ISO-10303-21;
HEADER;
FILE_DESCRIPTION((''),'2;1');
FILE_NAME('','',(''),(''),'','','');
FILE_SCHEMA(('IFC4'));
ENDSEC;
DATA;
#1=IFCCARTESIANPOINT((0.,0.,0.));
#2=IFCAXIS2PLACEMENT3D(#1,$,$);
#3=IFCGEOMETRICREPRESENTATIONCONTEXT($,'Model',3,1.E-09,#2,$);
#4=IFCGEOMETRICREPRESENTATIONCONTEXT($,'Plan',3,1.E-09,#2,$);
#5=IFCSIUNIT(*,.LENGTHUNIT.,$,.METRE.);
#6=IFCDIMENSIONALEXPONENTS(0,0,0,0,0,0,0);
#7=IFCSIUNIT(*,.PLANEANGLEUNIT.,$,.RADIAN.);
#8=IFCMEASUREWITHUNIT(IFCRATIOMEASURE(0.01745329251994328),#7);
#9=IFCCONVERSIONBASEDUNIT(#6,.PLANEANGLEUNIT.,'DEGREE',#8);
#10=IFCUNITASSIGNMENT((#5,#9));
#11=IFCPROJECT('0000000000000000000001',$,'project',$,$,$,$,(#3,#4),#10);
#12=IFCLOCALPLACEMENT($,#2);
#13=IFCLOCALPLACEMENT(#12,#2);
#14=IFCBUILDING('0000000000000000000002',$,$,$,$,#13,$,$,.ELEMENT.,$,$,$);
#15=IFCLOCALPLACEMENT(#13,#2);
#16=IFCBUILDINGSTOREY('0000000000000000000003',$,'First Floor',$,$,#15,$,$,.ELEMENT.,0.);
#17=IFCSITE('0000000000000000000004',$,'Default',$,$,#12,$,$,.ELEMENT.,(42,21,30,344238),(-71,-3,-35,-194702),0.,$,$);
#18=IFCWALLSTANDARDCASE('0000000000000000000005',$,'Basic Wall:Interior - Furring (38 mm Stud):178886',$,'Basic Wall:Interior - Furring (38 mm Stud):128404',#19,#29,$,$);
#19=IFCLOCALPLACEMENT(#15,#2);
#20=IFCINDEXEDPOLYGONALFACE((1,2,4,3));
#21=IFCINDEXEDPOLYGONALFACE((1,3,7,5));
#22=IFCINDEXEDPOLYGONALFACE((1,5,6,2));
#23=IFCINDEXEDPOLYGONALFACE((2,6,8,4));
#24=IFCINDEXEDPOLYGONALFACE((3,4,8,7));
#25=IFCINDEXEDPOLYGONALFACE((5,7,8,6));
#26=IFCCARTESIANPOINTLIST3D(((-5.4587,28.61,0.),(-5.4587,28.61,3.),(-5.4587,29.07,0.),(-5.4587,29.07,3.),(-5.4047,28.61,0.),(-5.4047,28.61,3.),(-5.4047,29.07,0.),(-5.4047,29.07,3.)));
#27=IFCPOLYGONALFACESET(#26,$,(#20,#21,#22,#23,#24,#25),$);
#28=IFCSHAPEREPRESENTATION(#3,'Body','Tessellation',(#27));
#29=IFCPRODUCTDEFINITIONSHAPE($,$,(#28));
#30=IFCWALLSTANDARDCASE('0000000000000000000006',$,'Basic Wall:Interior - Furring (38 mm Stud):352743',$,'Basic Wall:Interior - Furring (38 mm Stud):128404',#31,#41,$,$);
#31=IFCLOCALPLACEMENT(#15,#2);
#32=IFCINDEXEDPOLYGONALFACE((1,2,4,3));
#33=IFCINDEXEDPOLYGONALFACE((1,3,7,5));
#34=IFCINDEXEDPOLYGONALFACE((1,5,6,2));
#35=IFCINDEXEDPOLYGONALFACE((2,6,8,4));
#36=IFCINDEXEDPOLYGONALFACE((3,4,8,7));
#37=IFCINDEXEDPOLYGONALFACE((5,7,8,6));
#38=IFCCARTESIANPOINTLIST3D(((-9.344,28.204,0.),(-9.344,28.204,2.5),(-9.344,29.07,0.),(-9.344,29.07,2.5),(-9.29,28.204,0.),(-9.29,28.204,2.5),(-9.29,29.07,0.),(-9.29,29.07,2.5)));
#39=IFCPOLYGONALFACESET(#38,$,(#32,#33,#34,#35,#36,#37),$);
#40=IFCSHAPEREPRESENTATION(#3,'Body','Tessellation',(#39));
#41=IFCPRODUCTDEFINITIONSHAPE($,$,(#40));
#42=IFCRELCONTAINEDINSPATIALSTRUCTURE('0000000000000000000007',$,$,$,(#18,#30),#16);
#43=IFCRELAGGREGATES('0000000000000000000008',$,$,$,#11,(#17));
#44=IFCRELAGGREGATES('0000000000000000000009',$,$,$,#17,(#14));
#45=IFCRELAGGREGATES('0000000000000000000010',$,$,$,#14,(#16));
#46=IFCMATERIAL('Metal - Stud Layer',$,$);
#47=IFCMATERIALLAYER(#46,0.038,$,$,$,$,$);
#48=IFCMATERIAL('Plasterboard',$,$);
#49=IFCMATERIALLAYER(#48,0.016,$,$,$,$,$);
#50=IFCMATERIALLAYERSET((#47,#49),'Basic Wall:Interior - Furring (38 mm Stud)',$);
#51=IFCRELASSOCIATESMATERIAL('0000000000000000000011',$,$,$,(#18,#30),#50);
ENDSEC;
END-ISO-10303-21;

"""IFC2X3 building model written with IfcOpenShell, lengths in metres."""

from ifc_helpers import new_model, entity, si_unit, converted_unit, frame, frame_2d, origin, place, context, project, spatial, rectangle, extrude, material, layer, layer_set, layer_usage, element, save


model = new_model("IFC2X3")

# Units and contexts
model_context = context("Model", 3, precision=1e-09, world=origin())
plan_context = context("Plan", 3, precision=1e-09, world=origin())
ifc_project = project(units=[si_unit("LENGTHUNIT", "METRE"), converted_unit("PLANEANGLEUNIT", "DEGREE", entity("IfcRatioMeasure", 0.01745329251994328), si_unit("PLANEANGLEUNIT", "RADIAN"), dimensions=[0, 0, 0, 0, 0, 0, 0])], contexts=[model_context, plan_context])

# Site, building, storey
site_placement = place(None, origin())
site = spatial("IfcSite", under=ifc_project, at=site_placement, Name="Default", CompositionType="ELEMENT", RefLatitude=(42, 21, 30, 344238), RefLongitude=(-71, -3, -35, -194702), RefElevation=0.0)
building_placement = place(site_placement, origin())
building = spatial("IfcBuilding", under=site, at=building_placement, CompositionType="ELEMENT")
storey_placement = place(building_placement, origin())
storey = spatial("IfcBuildingStorey", under=building, at=storey_placement, Name="First Floor", CompositionType="ELEMENT", Elevation=0.0)

# Shared definitions
ifc_material_1 = material(Name="Plasterboard")
ifc_material_2 = material(Name="Metal - Stud Layer")

# Shared definitions
ifc_layer_1 = layer(ifc_material_2, 0.038)
ifc_layer_2 = layer(ifc_material_1, 0.016)
ifc_layer_set_1 = layer_set([ifc_layer_1, ifc_layer_2], Name="Basic Wall:Interior - Furring (38 mm Stud)")
ifc_layer_usage_1 = layer_usage(ifc_layer_set_1, "AXIS2", "POSITIVE", -0.027)

# Walls
wall_1_placement = place(storey_placement, frame((-5.4317, 28.61, 0.0), z_axis=(0.0, 0.0, 1.0), x_axis=(0.0, 1.0, 0.0)))
element("IfcWallStandardCase", 1, at=wall_1_placement, inside=storey, material=ifc_layer_usage_1, Name="Basic Wall:Interior - Furring (38 mm Stud):178886", ObjectType="Basic Wall:Interior - Furring (38 mm Stud):128404", context=model_context, shape_type="SweptSolid", body=[
    extrude(rectangle(XDim=0.46, YDim=0.054, at=frame_2d((0.23, 0.0), x_axis=(-1.0, 0.0))), origin(), (0.0, 0.0, 1.0), 3.0),
])
wall_2_placement = place(storey_placement, frame((-9.317, 29.07, 0.0), z_axis=(0.0, 0.0, 1.0), x_axis=(0.0, -1.0, 0.0)))
element("IfcWallStandardCase", 2, at=wall_2_placement, inside=storey, material=ifc_layer_usage_1, Name="Basic Wall:Interior - Furring (38 mm Stud):352743", ObjectType="Basic Wall:Interior - Furring (38 mm Stud):128404", context=model_context, shape_type="SweptSolid", body=[
    extrude(rectangle(XDim=0.866, YDim=0.054, at=frame_2d((0.433, 0.0), x_axis=(-1.0, 0.0))), origin(), (0.0, 0.0, 1.0), 2.5),
])

save(model, "model.ifc")
